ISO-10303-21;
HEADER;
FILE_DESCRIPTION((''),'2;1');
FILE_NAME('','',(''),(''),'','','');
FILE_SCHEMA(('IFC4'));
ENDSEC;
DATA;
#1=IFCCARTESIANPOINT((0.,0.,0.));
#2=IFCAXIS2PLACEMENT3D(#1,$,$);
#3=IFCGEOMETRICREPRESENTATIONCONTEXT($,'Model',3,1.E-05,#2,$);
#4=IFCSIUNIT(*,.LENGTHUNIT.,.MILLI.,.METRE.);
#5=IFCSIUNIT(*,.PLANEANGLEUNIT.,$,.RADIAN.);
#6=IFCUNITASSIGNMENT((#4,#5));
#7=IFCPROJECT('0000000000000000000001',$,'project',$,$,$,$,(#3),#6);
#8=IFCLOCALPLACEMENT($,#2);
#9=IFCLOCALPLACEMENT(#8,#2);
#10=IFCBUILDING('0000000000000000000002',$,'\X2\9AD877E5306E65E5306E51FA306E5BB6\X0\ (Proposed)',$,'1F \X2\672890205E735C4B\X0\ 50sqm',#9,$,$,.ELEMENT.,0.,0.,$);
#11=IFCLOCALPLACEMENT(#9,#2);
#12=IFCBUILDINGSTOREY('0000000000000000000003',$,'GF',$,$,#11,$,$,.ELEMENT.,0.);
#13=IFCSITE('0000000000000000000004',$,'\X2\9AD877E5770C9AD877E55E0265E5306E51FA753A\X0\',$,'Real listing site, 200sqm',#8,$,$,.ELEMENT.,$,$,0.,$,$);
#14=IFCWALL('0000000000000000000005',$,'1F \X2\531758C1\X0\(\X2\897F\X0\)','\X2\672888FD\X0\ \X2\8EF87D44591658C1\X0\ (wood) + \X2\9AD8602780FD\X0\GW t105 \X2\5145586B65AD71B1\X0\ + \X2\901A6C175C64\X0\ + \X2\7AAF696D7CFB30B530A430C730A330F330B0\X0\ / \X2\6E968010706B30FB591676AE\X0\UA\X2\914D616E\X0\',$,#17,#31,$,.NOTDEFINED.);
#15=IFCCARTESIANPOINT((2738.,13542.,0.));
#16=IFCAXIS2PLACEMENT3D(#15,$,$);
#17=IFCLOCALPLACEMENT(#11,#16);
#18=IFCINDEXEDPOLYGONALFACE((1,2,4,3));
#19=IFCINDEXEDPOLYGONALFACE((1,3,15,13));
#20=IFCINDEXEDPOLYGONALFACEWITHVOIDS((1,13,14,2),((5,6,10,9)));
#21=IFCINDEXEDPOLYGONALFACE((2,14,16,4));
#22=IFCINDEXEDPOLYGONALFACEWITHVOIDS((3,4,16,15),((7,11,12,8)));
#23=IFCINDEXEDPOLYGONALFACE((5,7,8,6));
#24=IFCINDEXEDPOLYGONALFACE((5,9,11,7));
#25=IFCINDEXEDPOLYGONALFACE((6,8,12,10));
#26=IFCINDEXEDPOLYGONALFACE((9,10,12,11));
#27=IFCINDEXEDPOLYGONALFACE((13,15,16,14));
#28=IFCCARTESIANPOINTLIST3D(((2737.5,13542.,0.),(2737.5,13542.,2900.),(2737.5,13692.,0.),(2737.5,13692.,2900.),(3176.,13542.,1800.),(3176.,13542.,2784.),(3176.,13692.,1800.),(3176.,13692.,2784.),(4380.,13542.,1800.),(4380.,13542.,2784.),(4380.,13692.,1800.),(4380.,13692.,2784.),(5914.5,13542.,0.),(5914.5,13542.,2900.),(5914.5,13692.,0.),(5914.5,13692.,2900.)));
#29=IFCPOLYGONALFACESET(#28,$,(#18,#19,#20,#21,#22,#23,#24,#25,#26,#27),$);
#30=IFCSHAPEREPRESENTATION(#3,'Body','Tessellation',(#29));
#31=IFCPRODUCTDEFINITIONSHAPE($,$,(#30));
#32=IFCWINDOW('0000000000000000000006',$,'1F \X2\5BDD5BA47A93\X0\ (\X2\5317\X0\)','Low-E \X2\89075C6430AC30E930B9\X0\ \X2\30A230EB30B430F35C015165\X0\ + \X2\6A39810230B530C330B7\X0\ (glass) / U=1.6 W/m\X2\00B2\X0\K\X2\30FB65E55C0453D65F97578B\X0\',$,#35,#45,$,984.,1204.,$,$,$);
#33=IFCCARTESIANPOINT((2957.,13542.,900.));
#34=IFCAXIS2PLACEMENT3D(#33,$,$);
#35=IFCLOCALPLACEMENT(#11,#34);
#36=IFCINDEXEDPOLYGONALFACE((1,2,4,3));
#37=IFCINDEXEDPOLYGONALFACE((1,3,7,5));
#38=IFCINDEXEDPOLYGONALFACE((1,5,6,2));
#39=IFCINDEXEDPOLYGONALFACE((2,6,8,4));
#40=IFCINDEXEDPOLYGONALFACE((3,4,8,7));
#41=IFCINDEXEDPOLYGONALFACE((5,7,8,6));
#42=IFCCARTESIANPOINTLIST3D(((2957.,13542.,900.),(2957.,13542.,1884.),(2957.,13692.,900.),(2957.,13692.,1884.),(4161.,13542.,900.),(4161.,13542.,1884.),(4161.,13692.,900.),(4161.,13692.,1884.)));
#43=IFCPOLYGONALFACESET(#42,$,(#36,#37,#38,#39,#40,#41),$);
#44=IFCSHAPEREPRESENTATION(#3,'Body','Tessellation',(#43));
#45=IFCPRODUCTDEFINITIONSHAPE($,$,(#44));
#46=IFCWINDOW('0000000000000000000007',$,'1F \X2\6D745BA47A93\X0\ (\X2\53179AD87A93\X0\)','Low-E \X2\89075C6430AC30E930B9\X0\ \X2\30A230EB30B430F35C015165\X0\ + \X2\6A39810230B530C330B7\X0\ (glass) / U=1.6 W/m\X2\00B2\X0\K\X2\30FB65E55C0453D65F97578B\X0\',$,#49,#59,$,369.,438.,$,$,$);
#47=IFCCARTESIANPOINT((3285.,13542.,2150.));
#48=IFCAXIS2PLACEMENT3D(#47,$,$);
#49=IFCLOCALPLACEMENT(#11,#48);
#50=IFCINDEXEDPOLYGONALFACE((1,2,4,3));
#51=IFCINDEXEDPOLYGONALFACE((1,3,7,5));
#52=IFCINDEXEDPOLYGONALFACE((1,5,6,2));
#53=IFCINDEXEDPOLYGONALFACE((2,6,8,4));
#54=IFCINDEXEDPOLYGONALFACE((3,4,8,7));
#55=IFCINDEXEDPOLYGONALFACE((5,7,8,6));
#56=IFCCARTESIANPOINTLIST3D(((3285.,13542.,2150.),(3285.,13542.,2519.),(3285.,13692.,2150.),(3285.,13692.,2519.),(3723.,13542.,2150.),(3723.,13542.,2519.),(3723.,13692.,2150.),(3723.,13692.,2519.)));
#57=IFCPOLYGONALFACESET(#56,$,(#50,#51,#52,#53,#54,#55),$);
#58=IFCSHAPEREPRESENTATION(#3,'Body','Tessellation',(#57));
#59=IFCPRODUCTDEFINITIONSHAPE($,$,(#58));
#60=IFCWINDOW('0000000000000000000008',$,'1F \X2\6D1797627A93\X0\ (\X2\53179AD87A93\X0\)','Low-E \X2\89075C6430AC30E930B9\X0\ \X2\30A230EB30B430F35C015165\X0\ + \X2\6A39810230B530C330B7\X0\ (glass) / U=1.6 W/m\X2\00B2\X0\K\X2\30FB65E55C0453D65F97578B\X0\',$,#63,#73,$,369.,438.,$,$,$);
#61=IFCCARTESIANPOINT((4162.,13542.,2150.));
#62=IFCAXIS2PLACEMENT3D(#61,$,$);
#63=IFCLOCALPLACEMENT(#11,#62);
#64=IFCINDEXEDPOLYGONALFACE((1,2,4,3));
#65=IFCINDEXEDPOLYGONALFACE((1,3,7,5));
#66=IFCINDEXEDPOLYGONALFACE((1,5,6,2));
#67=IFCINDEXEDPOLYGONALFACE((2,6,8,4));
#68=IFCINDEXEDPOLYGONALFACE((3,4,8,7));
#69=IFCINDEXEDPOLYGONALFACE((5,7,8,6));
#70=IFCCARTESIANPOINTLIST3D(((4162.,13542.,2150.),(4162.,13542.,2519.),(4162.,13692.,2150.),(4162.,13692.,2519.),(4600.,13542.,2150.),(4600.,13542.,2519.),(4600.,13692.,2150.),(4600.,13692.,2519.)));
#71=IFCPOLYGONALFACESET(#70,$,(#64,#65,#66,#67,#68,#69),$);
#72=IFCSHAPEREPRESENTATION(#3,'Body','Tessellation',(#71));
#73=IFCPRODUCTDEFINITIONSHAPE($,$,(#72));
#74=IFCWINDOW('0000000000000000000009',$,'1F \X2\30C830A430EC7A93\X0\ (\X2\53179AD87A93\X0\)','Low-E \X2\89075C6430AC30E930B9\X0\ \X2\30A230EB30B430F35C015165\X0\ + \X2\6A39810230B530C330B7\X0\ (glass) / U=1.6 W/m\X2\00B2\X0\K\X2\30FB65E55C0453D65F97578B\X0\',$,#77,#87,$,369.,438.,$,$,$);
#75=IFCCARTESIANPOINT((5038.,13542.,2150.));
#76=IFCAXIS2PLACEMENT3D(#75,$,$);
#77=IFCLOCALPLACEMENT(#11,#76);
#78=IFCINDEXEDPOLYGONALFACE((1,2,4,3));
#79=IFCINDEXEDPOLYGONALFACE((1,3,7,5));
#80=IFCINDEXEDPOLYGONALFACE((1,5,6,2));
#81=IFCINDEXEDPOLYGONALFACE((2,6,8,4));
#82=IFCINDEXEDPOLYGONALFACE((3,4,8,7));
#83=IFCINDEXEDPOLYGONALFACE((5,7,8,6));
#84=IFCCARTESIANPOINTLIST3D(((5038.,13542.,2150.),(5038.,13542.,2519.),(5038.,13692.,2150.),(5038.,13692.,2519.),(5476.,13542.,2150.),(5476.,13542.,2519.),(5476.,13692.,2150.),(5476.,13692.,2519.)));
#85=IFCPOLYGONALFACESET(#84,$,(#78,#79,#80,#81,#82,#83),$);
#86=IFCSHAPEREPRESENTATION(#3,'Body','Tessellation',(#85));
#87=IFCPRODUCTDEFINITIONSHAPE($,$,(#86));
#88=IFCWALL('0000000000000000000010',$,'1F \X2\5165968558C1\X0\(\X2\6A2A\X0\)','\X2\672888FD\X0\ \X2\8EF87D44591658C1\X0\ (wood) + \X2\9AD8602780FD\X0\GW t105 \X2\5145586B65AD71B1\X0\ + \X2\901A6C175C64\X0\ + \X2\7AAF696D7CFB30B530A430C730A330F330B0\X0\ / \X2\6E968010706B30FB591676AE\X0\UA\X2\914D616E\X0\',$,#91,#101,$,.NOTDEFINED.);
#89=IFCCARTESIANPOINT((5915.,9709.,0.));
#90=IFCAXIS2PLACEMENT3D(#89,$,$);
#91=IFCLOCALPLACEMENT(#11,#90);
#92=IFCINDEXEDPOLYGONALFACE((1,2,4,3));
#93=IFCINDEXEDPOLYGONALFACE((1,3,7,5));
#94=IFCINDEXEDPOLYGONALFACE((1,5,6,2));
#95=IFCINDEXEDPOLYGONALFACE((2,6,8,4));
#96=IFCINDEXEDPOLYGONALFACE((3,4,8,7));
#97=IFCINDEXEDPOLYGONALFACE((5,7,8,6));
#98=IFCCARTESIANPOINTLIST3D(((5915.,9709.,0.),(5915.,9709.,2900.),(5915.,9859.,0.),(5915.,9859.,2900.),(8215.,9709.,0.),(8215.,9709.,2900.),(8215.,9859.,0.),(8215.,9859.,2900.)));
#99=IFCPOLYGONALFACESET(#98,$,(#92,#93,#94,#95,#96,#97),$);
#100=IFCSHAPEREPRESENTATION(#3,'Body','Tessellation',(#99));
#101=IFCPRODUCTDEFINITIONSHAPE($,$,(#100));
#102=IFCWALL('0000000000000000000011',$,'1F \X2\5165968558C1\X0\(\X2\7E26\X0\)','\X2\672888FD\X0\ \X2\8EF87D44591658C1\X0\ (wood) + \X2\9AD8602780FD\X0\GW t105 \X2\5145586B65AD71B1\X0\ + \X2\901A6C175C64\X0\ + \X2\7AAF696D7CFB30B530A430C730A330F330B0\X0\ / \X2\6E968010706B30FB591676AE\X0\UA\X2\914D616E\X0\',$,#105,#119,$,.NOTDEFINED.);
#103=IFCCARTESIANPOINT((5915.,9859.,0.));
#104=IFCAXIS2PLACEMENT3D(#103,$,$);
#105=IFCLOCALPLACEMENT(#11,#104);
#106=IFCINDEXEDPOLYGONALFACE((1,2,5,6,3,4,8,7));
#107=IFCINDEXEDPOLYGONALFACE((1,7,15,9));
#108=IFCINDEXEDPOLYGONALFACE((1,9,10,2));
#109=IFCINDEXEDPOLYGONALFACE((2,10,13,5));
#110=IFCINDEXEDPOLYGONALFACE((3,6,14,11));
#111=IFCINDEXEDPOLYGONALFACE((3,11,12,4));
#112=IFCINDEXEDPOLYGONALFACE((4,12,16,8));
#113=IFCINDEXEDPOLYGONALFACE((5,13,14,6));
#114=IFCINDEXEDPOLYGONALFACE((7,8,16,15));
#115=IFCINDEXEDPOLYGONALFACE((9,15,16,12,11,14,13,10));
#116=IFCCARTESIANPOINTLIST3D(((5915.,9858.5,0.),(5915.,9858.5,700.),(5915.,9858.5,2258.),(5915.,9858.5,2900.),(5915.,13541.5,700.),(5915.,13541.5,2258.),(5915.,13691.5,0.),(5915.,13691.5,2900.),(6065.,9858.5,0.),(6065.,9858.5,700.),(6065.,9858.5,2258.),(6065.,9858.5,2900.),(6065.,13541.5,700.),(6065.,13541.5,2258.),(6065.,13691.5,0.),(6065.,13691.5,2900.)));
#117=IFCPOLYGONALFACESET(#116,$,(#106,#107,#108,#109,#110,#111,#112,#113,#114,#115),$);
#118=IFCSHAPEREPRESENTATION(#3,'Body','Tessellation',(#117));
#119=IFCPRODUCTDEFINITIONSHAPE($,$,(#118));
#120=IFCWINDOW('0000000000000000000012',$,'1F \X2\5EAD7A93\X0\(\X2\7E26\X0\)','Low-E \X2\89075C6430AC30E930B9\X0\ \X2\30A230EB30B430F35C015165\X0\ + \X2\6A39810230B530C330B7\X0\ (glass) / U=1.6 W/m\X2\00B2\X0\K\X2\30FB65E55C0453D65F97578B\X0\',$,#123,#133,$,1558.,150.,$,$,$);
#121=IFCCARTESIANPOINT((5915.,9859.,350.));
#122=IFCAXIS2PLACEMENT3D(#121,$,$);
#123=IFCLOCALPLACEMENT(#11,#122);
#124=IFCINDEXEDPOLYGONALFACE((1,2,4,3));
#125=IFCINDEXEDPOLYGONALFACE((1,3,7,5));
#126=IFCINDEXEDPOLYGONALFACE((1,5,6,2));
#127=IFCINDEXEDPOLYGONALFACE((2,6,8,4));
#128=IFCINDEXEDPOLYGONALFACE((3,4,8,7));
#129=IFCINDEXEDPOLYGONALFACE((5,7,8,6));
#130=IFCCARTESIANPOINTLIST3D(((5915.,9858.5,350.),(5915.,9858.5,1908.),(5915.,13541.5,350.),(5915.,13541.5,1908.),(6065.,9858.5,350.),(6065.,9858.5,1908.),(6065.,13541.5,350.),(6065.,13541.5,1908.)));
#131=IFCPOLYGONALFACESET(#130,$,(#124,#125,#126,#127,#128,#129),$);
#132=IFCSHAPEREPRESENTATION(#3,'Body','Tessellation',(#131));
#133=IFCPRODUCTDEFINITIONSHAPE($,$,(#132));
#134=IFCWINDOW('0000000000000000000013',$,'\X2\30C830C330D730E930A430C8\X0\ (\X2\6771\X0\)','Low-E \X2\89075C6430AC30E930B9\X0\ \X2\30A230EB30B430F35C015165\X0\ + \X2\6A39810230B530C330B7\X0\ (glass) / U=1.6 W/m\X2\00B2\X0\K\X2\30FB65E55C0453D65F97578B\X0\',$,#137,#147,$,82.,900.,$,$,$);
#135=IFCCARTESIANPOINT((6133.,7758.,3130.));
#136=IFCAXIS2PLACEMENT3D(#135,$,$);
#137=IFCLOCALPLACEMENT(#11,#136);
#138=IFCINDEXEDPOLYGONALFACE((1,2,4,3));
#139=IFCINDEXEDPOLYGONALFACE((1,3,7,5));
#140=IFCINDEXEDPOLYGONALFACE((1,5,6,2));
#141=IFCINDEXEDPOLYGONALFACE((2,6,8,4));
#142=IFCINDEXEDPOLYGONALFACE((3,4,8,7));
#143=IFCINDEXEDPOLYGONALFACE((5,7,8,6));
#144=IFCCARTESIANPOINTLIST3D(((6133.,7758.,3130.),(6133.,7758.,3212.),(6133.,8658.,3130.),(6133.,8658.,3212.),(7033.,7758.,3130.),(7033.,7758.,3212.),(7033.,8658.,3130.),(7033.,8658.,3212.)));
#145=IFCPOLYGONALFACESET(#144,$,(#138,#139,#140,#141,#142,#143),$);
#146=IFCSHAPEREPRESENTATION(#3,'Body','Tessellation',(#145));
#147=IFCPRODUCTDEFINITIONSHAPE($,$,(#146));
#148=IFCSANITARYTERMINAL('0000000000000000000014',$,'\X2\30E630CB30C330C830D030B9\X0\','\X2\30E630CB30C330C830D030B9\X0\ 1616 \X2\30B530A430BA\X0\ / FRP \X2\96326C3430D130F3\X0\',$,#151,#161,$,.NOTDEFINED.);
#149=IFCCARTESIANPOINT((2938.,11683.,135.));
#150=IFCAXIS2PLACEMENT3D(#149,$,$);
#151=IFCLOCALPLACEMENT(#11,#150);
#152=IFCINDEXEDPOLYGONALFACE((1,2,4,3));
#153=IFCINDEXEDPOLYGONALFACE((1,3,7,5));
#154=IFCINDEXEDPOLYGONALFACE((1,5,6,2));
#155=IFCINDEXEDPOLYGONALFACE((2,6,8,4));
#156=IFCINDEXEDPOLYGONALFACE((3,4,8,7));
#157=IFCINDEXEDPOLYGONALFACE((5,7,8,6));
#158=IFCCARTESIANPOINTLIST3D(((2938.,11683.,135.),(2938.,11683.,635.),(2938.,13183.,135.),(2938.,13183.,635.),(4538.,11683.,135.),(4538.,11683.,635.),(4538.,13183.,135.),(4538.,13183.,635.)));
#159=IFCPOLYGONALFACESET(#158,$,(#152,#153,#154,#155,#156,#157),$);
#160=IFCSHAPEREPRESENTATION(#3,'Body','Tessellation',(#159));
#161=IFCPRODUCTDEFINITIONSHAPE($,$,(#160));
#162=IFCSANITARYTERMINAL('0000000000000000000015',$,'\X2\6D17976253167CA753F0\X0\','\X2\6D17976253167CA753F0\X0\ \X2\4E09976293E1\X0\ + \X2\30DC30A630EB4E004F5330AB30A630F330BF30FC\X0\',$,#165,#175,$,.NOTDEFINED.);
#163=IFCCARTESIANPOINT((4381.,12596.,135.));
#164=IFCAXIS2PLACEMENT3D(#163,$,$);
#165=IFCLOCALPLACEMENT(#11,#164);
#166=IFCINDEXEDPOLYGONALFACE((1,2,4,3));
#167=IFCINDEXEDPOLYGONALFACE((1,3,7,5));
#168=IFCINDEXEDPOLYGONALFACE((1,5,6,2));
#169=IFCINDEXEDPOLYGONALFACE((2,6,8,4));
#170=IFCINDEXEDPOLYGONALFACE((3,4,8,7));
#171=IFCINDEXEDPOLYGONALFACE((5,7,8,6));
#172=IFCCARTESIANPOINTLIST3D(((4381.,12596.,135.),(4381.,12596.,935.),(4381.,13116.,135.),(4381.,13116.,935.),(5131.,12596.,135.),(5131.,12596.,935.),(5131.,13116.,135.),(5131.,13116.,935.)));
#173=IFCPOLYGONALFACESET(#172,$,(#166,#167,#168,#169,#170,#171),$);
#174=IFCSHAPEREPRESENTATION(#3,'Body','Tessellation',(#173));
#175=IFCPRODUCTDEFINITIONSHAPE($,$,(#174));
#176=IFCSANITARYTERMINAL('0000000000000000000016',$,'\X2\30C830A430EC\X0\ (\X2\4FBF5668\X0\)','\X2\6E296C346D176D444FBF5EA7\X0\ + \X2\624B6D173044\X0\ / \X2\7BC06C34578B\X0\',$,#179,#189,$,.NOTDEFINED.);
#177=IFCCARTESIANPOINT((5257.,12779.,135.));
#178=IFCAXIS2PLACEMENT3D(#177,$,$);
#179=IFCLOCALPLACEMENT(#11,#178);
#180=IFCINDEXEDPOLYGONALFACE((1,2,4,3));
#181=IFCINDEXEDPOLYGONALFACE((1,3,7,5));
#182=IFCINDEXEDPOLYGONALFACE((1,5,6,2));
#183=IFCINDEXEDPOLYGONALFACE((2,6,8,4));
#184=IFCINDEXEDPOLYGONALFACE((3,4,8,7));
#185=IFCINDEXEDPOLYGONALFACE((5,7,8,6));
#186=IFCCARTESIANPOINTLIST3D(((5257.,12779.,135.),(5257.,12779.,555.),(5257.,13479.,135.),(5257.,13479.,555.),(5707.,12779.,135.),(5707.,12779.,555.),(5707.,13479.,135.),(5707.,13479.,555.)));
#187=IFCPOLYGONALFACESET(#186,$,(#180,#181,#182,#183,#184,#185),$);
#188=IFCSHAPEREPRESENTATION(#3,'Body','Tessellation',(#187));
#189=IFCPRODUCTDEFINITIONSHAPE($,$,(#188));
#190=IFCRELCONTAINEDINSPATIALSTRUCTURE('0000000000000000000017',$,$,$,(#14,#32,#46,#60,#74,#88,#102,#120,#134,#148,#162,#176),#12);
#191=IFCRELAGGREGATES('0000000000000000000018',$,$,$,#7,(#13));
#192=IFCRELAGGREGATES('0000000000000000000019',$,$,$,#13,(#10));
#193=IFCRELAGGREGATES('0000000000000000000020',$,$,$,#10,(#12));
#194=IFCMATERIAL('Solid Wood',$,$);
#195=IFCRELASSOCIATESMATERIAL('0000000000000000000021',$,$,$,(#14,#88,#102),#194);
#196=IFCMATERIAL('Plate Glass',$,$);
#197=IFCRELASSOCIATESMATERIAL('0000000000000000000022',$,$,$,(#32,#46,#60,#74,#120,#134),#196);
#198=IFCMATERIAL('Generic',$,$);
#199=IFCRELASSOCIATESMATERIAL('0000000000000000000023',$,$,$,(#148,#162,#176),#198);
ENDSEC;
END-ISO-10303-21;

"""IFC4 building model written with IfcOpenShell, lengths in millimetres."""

from ifc_helpers import new_model, si_unit, frame, frame_2d, origin, place, context, project, spatial, rectangle, extrude, material, element, fill, save


model = new_model("IFC4")

# Units and contexts
model_context = context("Model", 3, precision=1e-05, world=origin())
ifc_project = project(units=[si_unit("LENGTHUNIT", "METRE", prefix="MILLI"), si_unit("PLANEANGLEUNIT", "RADIAN")], contexts=[model_context])

# Site, building, storey
site_placement = place(None, origin())
site = spatial("IfcSite", under=ifc_project, at=site_placement, Name="高知県高知市日の出町", ObjectType="Real listing site, 200sqm", CompositionType="ELEMENT", RefElevation=0.0)
building_placement = place(site_placement, origin())
building = spatial("IfcBuilding", under=site, at=building_placement, Name="高知の日の出の家 (Proposed)", ObjectType="1F 木造平屋 50sqm", CompositionType="ELEMENT", ElevationOfRefHeight=0.0, ElevationOfTerrain=0.0)
storey_placement = place(building_placement, origin())
storey = spatial("IfcBuildingStorey", under=building, at=storey_placement, Name="GF", CompositionType="ELEMENT", Elevation=0.0)

# Shared definitions
ifc_material_1 = material(Name="Solid Wood")

# Wall, openings, windows
wall_1_placement = place(storey_placement, frame((2738.0, 13542.0, 0.0)))
wall_1 = element("IfcWall", 1, at=wall_1_placement, inside=storey, material=ifc_material_1, Name="1F 北壁(西)", Description="木製 軸組外壁 (wood) + 高性能GW t105 充填断熱 + 通気層 + 窯業系サイディング / 準耐火・外皮UA配慮", PredefinedType="NOTDEFINED", context=model_context, shape_type="SweptSolid", body=[
    extrude(rectangle(XDim=3177.0, YDim=150.0, at=frame_2d((1588.0, 75.0))), frame((2738.0, 13542.0, 0.0)), (0.0, 0.0, 1.0), 2900.0),
])
opening_1_placement = place(storey_placement, frame((2957.0, 13542.0, 900.0)))
opening_1 = element("IfcOpeningElement", 2, at=opening_1_placement, cuts=wall_1, PredefinedType="NOTDEFINED", context=model_context, shape_type="SweptSolid", body=[
    extrude(rectangle(XDim=1204.0, YDim=150.0, at=frame_2d((602.0, 75.0))), frame((2957.0, 13542.0, 900.0)), (0.0, 0.0, 1.0), 984.0),
])
opening_2_placement = place(storey_placement, frame((3285.0, 13542.0, 2150.0)))
opening_2 = element("IfcOpeningElement", 3, at=opening_2_placement, cuts=wall_1, PredefinedType="NOTDEFINED", context=model_context, shape_type="SweptSolid", body=[
    extrude(rectangle(XDim=438.0, YDim=150.0, at=frame_2d((219.0, 75.0))), frame((3285.0, 13542.0, 2150.0)), (0.0, 0.0, 1.0), 369.0),
])
opening_3_placement = place(storey_placement, frame((4162.0, 13542.0, 2150.0)))
opening_3 = element("IfcOpeningElement", 4, at=opening_3_placement, cuts=wall_1, PredefinedType="NOTDEFINED", context=model_context, shape_type="SweptSolid", body=[
    extrude(rectangle(XDim=438.0, YDim=150.0, at=frame_2d((219.0, 75.0))), frame((4162.0, 13542.0, 2150.0)), (0.0, 0.0, 1.0), 369.0),
])
opening_4_placement = place(storey_placement, frame((5038.0, 13542.0, 2150.0)))
opening_4 = element("IfcOpeningElement", 5, at=opening_4_placement, cuts=wall_1, PredefinedType="NOTDEFINED", context=model_context, shape_type="SweptSolid", body=[
    extrude(rectangle(XDim=438.0, YDim=150.0, at=frame_2d((219.0, 75.0))), frame((5038.0, 13542.0, 2150.0)), (0.0, 0.0, 1.0), 369.0),
])
ifc_material_2 = material(Name="Plate Glass")
window_1_placement = place(storey_placement, frame((2957.0, 13542.0, 900.0)))
window_1 = element("IfcWindow", 6, at=window_1_placement, inside=storey, material=ifc_material_2, Name="1F 寝室窓 (北)", Description="Low-E 複層ガラス アルゴン封入 + 樹脂サッシ (glass) / U=1.6 W/m²K・日射取得型", OverallHeight=984.0, OverallWidth=1204.0, context=model_context, shape_type="SweptSolid", body=[
    extrude(rectangle(XDim=1204.0, YDim=150.0, at=frame_2d((602.0, 75.0))), frame((2957.0, 13542.0, 900.0)), (0.0, 0.0, 1.0), 984.0),
])
fill(opening_1, window_1)
window_2_placement = place(storey_placement, frame((3285.0, 13542.0, 2150.0)))
window_2 = element("IfcWindow", 7, at=window_2_placement, inside=storey, material=ifc_material_2, Name="1F 浴室窓 (北高窓)", Description="Low-E 複層ガラス アルゴン封入 + 樹脂サッシ (glass) / U=1.6 W/m²K・日射取得型", OverallHeight=369.0, OverallWidth=438.0, context=model_context, shape_type="SweptSolid", body=[
    extrude(rectangle(XDim=438.0, YDim=150.0, at=frame_2d((219.0, 75.0))), frame((3285.0, 13542.0, 2150.0)), (0.0, 0.0, 1.0), 369.0),
])
fill(opening_2, window_2)
window_3_placement = place(storey_placement, frame((4162.0, 13542.0, 2150.0)))
window_3 = element("IfcWindow", 8, at=window_3_placement, inside=storey, material=ifc_material_2, Name="1F 洗面窓 (北高窓)", Description="Low-E 複層ガラス アルゴン封入 + 樹脂サッシ (glass) / U=1.6 W/m²K・日射取得型", OverallHeight=369.0, OverallWidth=438.0, context=model_context, shape_type="SweptSolid", body=[
    extrude(rectangle(XDim=438.0, YDim=150.0, at=frame_2d((219.0, 75.0))), frame((4162.0, 13542.0, 2150.0)), (0.0, 0.0, 1.0), 369.0),
])
fill(opening_3, window_3)
window_4_placement = place(storey_placement, frame((5038.0, 13542.0, 2150.0)))
window_4 = element("IfcWindow", 9, at=window_4_placement, inside=storey, material=ifc_material_2, Name="1F トイレ窓 (北高窓)", Description="Low-E 複層ガラス アルゴン封入 + 樹脂サッシ (glass) / U=1.6 W/m²K・日射取得型", OverallHeight=369.0, OverallWidth=438.0, context=model_context, shape_type="SweptSolid", body=[
    extrude(rectangle(XDim=438.0, YDim=150.0, at=frame_2d((219.0, 75.0))), frame((5038.0, 13542.0, 2150.0)), (0.0, 0.0, 1.0), 369.0),
])
fill(opening_4, window_4)

# Wall
wall_2_placement = place(storey_placement, frame((5915.0, 9709.0, 0.0)))
element("IfcWall", 10, at=wall_2_placement, inside=storey, material=ifc_material_1, Name="1F 入隅壁(横)", Description="木製 軸組外壁 (wood) + 高性能GW t105 充填断熱 + 通気層 + 窯業系サイディング / 準耐火・外皮UA配慮", PredefinedType="NOTDEFINED", context=model_context, shape_type="SweptSolid", body=[
    extrude(rectangle(XDim=2300.0, YDim=150.0, at=frame_2d((1150.0, 75.0))), frame((5915.0, 9709.0, 0.0)), (0.0, 0.0, 1.0), 2900.0),
])

# Wall, opening, window
wall_3_placement = place(storey_placement, frame((5915.0, 9859.0, 0.0)))
wall_3 = element("IfcWall", 11, at=wall_3_placement, inside=storey, material=ifc_material_1, Name="1F 入隅壁(縦)", Description="木製 軸組外壁 (wood) + 高性能GW t105 充填断熱 + 通気層 + 窯業系サイディング / 準耐火・外皮UA配慮", PredefinedType="NOTDEFINED", context=model_context, shape_type="SweptSolid", body=[
    extrude(rectangle(XDim=150.0, YDim=3833.0, at=frame_2d((75.0, 1916.0))), frame((5915.0, 9859.0, 0.0)), (0.0, 0.0, 1.0), 2900.0),
])
opening_5_placement = place(storey_placement, frame((5915.0, 9859.0, 350.0)))
opening_5 = element("IfcOpeningElement", 12, at=opening_5_placement, cuts=wall_3, PredefinedType="NOTDEFINED", context=model_context, shape_type="SweptSolid", body=[
    extrude(rectangle(XDim=150.0, YDim=3683.0, at=frame_2d((75.0, 1841.0))), frame((5915.0, 9859.0, 350.0)), (0.0, 0.0, 1.0), 1558.0),
])
window_5_placement = place(storey_placement, frame((5915.0, 9859.0, 350.0)))
window_5 = element("IfcWindow", 13, at=window_5_placement, inside=storey, material=ifc_material_2, Name="1F 庭窓(縦)", Description="Low-E 複層ガラス アルゴン封入 + 樹脂サッシ (glass) / U=1.6 W/m²K・日射取得型", OverallHeight=1558.0, OverallWidth=150.0, context=model_context, shape_type="SweptSolid", body=[
    extrude(rectangle(XDim=150.0, YDim=3683.0, at=frame_2d((75.0, 1841.0))), frame((5915.0, 9859.0, 350.0)), (0.0, 0.0, 1.0), 1558.0),
])
fill(opening_5, window_5)

# Window
window_6_placement = place(storey_placement, frame((6133.0, 7758.0, 3130.0)))
element("IfcWindow", 14, at=window_6_placement, inside=storey, material=ifc_material_2, Name="トップライト (東)", Description="Low-E 複層ガラス アルゴン封入 + 樹脂サッシ (glass) / U=1.6 W/m²K・日射取得型", OverallHeight=82.0, OverallWidth=900.0, context=model_context, shape_type="SweptSolid", body=[
    extrude(rectangle(XDim=900.0, YDim=900.0, at=frame_2d((450.0, 450.0))), frame((6133.0, 7758.0, 3130.0)), (0.0, 0.0, 1.0), 82.0),
])

# Shared definitions
ifc_material_3 = material(Name="Generic")

# Sanitary terminals
sanitary_terminal_1_placement = place(storey_placement, frame((2938.0, 11683.0, 135.0)))
element("IfcSanitaryTerminal", 15, at=sanitary_terminal_1_placement, inside=storey, material=ifc_material_3, Name="ユニットバス", Description="ユニットバス 1616 サイズ / FRP 防水パン", PredefinedType="NOTDEFINED", context=model_context, shape_type="SweptSolid", body=[
    extrude(rectangle(XDim=1600.0, YDim=1500.0, at=frame_2d((800.0, 750.0))), frame((2938.0, 11683.0, 135.0)), (0.0, 0.0, 1.0), 500.0),
])
sanitary_terminal_2_placement = place(storey_placement, frame((4381.0, 12596.0, 135.0)))
element("IfcSanitaryTerminal", 16, at=sanitary_terminal_2_placement, inside=storey, material=ifc_material_3, Name="洗面化粧台", Description="洗面化粧台 三面鏡 + ボウル一体カウンター", PredefinedType="NOTDEFINED", context=model_context, shape_type="SweptSolid", body=[
    extrude(rectangle(XDim=750.0, YDim=520.0, at=frame_2d((375.0, 260.0))), frame((4381.0, 12596.0, 135.0)), (0.0, 0.0, 1.0), 800.0),
])
sanitary_terminal_3_placement = place(storey_placement, frame((5257.0, 12779.0, 135.0)))
element("IfcSanitaryTerminal", 17, at=sanitary_terminal_3_placement, inside=storey, material=ifc_material_3, Name="トイレ (便器)", Description="温水洗浄便座 + 手洗い / 節水型", PredefinedType="NOTDEFINED", context=model_context, shape_type="SweptSolid", body=[
    extrude(rectangle(XDim=450.0, YDim=700.0, at=frame_2d((225.0, 350.0))), frame((5257.0, 12779.0, 135.0)), (0.0, 0.0, 1.0), 420.0),
])

save(model, "model.ifc")
